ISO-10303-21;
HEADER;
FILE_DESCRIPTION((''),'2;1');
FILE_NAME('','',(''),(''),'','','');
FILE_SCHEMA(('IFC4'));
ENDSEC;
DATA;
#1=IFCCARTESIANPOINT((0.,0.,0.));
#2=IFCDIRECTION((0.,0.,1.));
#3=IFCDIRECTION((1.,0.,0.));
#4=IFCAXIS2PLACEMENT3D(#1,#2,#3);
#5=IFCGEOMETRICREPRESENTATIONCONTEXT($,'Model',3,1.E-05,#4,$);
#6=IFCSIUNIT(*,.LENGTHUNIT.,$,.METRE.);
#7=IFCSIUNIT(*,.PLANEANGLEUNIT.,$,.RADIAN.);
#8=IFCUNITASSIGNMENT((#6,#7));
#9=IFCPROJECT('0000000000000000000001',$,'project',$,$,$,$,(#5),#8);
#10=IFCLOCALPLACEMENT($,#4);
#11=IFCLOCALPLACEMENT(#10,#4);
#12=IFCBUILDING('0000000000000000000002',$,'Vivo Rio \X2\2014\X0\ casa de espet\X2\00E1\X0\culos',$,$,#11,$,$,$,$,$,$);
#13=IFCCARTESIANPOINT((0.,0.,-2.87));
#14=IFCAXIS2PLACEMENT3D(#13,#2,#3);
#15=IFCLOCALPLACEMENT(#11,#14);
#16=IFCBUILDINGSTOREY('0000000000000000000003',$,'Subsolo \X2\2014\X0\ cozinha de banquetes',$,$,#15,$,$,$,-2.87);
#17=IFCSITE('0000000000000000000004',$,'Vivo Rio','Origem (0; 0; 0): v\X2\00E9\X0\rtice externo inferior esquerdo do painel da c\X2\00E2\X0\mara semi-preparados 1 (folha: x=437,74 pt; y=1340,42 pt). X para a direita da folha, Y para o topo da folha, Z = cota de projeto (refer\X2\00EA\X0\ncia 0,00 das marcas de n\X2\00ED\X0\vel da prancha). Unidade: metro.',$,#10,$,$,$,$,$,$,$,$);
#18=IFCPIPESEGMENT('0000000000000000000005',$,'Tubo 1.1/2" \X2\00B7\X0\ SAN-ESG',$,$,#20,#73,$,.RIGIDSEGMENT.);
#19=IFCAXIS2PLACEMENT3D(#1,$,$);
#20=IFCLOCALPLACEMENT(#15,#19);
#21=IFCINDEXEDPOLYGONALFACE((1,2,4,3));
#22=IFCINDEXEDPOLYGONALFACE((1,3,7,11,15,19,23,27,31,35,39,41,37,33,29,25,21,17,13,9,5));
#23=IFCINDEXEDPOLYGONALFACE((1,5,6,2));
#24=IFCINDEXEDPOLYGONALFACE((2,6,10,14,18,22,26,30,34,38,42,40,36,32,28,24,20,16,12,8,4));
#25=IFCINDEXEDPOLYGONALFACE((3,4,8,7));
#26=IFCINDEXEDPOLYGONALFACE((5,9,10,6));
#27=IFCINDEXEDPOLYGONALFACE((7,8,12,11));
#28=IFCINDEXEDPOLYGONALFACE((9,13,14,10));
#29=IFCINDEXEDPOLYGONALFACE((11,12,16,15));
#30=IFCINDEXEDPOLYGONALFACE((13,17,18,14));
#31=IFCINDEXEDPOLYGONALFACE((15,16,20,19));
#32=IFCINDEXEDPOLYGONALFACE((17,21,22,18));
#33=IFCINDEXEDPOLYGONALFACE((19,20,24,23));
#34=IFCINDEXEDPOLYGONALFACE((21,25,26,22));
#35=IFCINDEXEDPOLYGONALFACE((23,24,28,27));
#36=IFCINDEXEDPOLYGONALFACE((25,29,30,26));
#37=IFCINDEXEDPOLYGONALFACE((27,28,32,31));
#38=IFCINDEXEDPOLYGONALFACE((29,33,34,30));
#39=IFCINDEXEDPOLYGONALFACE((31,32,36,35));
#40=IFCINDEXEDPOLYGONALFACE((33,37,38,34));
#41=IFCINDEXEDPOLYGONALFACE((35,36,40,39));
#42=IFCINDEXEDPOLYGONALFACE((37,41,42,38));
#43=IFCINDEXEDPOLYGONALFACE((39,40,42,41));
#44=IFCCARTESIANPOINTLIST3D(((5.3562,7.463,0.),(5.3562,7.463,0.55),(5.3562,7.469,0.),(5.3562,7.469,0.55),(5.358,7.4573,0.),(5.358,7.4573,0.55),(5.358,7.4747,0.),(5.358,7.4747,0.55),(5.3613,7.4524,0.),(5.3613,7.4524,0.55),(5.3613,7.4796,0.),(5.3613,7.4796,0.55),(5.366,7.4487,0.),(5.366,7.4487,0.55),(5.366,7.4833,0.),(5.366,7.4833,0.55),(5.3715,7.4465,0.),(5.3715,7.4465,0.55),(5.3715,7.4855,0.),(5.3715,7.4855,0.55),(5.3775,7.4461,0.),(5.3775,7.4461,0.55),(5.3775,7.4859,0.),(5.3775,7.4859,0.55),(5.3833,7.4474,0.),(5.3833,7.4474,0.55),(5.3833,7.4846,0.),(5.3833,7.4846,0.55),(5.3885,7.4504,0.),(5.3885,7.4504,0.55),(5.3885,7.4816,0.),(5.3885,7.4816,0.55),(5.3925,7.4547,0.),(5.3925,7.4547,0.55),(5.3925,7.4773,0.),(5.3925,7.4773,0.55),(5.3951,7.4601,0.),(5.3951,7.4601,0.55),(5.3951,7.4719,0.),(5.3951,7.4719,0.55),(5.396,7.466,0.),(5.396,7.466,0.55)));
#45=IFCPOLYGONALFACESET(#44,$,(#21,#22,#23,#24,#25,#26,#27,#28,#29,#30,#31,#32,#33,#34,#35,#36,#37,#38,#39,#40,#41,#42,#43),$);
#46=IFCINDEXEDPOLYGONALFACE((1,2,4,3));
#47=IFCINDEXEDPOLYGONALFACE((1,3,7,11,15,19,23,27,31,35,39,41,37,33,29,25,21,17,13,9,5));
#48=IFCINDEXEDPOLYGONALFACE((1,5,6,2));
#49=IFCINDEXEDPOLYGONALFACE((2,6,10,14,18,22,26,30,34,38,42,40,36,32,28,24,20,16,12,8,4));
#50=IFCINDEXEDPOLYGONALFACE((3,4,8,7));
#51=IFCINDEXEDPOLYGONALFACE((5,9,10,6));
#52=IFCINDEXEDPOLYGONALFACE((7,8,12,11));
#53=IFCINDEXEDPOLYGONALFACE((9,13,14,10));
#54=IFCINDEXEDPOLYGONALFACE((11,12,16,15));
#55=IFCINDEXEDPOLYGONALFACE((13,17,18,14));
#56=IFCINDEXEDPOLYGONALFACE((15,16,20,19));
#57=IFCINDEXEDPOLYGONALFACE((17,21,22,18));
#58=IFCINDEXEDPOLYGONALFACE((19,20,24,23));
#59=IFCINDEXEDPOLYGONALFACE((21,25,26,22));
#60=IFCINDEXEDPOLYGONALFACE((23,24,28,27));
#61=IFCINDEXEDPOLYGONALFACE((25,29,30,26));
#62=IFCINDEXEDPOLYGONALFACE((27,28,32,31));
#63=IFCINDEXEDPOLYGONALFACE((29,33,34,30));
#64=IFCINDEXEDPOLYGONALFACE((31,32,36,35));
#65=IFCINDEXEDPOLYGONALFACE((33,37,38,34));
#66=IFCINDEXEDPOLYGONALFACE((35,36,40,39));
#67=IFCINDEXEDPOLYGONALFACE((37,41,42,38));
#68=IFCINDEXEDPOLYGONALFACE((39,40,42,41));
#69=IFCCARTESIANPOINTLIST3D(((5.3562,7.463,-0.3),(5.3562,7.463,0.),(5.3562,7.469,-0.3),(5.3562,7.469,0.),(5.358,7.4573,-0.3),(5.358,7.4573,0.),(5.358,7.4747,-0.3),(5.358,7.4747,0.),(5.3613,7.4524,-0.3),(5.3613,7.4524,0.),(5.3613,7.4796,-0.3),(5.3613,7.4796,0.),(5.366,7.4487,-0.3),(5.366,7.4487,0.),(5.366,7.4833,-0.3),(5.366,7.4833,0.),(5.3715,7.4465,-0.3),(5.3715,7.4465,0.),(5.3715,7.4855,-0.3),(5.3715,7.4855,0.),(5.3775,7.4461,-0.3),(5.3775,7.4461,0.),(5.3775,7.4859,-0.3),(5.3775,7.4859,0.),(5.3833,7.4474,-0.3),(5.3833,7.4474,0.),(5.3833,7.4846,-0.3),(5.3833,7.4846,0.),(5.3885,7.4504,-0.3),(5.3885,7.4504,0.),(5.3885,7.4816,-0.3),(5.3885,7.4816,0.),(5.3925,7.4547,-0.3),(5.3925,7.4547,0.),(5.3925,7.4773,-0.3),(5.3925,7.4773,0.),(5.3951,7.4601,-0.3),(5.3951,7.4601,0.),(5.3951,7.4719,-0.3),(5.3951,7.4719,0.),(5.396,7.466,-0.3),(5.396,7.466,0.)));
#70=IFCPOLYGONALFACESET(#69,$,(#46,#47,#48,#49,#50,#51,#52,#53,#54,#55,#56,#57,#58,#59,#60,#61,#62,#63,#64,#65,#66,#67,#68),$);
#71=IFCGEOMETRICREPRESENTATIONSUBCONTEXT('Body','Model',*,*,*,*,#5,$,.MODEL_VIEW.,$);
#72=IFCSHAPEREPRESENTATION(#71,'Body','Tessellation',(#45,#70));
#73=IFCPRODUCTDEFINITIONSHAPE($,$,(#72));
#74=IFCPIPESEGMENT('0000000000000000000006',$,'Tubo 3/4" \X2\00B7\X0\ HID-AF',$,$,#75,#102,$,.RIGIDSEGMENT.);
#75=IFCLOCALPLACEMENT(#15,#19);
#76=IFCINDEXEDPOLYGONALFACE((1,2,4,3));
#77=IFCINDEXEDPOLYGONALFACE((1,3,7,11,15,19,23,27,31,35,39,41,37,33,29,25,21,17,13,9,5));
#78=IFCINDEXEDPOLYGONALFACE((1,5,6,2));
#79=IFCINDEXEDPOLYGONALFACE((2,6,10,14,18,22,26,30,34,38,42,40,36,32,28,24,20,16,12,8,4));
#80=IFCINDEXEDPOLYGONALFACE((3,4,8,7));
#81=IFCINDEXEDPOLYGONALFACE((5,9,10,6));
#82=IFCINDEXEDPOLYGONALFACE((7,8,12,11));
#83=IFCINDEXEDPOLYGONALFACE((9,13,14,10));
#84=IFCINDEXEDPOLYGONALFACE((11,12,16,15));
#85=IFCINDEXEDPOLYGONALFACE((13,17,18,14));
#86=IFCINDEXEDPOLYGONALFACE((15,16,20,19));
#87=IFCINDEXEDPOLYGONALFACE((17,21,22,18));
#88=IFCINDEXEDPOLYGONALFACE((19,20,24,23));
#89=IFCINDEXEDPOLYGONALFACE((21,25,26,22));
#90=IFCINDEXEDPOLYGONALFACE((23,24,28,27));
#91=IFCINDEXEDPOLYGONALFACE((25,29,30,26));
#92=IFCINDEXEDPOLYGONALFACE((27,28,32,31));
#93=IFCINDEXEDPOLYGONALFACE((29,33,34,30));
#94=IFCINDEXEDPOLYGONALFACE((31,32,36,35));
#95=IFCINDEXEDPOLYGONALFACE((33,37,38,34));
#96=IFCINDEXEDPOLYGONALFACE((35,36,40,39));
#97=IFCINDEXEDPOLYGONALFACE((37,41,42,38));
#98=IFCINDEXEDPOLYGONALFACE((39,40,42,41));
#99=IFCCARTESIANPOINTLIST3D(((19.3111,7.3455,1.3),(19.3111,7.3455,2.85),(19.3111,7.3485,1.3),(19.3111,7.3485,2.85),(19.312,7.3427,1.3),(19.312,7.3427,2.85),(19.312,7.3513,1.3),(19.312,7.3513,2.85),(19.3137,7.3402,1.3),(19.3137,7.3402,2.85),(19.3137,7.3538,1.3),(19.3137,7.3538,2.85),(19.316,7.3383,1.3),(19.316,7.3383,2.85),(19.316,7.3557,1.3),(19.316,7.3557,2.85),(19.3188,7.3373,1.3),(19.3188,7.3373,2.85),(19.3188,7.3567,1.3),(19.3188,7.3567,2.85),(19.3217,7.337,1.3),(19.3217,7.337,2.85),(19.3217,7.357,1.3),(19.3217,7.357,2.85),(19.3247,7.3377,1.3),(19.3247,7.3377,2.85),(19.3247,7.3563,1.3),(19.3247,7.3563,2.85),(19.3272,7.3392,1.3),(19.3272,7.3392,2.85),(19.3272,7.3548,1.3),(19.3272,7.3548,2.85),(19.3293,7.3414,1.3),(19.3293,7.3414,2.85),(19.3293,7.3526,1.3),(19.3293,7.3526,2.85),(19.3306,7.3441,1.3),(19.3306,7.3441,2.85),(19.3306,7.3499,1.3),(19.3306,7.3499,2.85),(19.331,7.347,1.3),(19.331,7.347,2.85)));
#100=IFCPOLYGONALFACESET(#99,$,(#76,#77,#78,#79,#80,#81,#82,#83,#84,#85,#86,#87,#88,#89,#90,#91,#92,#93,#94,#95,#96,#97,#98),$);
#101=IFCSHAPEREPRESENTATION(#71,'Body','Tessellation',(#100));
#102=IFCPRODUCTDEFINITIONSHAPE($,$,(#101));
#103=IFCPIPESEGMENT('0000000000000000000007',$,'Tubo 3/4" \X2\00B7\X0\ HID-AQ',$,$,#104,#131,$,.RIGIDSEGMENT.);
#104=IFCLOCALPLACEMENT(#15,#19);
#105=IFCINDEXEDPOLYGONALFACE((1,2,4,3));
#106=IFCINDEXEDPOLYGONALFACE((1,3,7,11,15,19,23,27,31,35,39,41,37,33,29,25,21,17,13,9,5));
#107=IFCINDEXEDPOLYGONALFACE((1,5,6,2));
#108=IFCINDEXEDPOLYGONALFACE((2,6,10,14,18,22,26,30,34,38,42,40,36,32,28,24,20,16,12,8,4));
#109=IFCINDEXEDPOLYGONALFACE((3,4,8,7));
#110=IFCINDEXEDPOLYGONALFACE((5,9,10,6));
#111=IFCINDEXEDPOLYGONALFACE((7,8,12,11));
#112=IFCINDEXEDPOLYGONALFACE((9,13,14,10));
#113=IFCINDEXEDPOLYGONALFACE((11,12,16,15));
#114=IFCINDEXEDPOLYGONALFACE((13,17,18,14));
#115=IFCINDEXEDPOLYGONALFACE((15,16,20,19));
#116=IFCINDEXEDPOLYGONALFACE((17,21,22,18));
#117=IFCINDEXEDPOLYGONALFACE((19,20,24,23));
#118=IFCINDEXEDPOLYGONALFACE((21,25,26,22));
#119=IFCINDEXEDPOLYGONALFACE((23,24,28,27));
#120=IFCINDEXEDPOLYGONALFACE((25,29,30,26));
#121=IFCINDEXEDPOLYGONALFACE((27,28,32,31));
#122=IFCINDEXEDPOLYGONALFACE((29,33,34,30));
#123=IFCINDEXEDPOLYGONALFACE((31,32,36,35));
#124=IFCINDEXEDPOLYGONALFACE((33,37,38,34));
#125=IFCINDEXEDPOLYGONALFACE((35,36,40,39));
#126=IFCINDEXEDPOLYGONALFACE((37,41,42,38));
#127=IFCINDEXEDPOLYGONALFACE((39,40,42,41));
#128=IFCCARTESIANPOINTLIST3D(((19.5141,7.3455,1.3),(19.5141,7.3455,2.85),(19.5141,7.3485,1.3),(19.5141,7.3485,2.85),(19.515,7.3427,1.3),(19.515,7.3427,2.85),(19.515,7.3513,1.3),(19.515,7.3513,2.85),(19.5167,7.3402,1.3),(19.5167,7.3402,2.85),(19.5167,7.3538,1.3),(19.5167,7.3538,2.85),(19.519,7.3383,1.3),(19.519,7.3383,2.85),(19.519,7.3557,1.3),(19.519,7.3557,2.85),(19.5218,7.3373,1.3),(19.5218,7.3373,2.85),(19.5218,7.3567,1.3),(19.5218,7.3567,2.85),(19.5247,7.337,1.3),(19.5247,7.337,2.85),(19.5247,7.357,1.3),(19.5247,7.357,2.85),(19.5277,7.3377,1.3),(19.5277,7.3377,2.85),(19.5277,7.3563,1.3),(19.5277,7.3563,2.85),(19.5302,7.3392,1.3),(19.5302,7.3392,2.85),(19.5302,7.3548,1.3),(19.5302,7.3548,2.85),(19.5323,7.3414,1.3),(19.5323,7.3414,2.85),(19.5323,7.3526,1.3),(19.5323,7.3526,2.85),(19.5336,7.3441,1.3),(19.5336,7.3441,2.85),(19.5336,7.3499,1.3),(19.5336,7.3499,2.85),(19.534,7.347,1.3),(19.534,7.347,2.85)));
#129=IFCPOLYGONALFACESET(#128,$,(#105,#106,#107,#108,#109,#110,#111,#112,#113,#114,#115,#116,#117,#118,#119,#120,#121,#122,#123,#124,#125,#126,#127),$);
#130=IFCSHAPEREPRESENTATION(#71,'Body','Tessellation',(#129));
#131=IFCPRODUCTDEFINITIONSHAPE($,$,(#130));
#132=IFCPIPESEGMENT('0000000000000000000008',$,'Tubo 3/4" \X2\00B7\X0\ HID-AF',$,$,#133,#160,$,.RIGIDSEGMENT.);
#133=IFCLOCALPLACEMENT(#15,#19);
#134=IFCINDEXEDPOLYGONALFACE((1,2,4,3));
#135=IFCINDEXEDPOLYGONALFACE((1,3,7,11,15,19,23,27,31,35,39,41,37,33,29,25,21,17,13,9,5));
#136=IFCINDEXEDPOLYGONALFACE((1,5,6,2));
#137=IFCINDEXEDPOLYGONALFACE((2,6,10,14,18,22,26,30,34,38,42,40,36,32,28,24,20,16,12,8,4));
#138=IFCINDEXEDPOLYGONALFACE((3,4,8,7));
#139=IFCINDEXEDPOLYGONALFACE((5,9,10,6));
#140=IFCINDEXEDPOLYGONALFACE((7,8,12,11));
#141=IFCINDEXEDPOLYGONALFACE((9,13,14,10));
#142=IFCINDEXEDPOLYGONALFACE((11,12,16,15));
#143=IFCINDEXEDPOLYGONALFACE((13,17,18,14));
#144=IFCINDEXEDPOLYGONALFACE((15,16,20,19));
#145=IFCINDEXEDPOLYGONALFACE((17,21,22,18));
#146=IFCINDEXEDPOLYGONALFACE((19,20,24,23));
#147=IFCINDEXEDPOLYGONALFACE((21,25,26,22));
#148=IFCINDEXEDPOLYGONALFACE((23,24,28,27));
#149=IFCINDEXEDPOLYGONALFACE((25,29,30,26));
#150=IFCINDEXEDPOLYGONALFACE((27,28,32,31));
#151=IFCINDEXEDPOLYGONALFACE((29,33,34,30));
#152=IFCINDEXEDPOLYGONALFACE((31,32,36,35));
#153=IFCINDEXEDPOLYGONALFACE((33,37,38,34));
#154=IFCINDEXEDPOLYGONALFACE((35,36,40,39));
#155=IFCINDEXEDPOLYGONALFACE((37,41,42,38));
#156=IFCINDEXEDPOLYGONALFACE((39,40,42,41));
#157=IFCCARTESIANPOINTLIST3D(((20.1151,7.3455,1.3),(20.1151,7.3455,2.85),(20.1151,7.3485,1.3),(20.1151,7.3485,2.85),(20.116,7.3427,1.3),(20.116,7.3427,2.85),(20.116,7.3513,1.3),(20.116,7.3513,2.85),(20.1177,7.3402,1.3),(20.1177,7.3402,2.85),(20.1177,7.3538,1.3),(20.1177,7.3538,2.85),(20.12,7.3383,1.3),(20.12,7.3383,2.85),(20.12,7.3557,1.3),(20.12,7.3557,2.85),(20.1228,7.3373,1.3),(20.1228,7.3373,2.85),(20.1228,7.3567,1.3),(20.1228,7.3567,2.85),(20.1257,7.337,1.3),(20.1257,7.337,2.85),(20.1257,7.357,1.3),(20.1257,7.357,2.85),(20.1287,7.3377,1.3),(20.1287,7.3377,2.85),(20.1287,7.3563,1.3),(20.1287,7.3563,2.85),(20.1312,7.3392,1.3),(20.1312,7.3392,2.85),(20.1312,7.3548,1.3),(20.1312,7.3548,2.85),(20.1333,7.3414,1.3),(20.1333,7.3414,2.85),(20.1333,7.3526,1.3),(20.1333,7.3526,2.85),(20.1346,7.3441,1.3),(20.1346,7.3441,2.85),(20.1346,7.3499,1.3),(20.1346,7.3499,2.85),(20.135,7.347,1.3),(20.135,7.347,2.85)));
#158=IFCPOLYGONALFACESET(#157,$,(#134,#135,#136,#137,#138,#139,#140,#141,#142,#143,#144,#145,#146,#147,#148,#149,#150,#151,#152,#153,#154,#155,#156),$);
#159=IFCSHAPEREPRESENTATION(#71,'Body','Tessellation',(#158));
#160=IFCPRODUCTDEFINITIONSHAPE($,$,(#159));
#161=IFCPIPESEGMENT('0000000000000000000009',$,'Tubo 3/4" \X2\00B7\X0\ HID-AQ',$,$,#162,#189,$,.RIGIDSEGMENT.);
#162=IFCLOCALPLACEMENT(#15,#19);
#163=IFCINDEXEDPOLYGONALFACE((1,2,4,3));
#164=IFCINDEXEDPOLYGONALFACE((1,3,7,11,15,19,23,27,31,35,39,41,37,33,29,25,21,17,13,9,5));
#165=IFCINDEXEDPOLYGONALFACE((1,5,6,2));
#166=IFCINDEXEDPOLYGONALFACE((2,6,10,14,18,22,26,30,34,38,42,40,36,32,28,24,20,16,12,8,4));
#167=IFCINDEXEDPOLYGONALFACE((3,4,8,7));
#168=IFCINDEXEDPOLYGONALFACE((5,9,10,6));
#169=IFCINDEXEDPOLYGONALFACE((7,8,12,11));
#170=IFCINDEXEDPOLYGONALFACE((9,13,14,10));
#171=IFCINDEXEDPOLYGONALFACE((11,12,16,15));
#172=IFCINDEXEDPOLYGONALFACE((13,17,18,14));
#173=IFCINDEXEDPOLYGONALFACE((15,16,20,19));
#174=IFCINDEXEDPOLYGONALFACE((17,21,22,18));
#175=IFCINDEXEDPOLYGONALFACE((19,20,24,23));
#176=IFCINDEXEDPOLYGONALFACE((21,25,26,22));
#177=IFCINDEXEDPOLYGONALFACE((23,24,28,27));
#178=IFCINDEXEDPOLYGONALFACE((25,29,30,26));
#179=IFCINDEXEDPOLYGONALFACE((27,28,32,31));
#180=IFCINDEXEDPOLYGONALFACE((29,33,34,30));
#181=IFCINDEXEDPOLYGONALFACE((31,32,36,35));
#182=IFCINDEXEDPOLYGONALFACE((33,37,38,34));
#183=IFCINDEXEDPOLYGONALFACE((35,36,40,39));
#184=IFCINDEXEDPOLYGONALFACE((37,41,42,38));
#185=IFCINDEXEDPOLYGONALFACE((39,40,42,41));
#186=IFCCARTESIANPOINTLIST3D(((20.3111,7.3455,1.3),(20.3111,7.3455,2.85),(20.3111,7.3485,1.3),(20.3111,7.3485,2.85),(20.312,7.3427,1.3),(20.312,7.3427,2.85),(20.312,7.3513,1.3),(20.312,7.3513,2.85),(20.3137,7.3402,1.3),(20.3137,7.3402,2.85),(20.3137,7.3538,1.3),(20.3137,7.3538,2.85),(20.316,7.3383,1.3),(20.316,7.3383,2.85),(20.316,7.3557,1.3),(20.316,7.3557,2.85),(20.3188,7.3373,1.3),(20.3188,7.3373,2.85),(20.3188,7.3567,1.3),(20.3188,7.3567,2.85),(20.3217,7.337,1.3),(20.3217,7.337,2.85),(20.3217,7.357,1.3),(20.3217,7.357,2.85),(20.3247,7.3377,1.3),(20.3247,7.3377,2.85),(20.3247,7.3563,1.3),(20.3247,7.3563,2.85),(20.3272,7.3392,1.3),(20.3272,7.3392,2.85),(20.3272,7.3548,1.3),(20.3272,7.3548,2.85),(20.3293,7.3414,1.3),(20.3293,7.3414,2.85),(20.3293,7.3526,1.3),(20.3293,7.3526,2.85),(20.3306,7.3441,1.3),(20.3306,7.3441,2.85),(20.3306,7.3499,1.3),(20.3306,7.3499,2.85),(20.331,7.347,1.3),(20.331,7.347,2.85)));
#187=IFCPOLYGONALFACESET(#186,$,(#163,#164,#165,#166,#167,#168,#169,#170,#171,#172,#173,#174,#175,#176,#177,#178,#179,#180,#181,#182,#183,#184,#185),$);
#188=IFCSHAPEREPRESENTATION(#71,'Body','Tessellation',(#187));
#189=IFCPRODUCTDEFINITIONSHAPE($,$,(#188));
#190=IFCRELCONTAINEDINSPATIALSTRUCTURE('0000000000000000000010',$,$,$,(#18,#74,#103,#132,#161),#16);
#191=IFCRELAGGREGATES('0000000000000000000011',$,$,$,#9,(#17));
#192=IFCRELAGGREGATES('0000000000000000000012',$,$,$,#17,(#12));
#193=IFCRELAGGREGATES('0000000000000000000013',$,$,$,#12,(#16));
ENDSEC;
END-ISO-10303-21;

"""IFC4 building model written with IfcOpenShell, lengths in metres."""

from ifc_helpers import new_model, si_unit, frame, origin_with_axes, origin_2d, place, context, subcontext, project, spatial, circle, extrude, element, save


model = new_model("IFC4")

# Units and contexts
model_context = context("Model", 3, precision=1e-05, world=origin_with_axes())
body_context = subcontext(model_context, "Body", "Model", "MODEL_VIEW")
ifc_project = project(units=[si_unit("LENGTHUNIT", "METRE"), si_unit("PLANEANGLEUNIT", "RADIAN")], contexts=[model_context])

# Site, building, storey
site_placement = place(None, origin_with_axes())
site = spatial("IfcSite", under=ifc_project, at=site_placement, Name="Vivo Rio", Description="Origem (0; 0; 0): vértice externo inferior esquerdo do painel da câmara semi-preparados 1 (folha: x=437,74 pt; y=1340,42 pt). X para a direita da folha, Y para o topo da folha, Z = cota de projeto (referência 0,00 das marcas de nível da prancha). Unidade: metro.")
building_placement = place(site_placement, origin_with_axes())
building = spatial("IfcBuilding", under=site, at=building_placement, Name="Vivo Rio — casa de espetáculos")
storey_placement = place(building_placement, frame((0.0, 0.0, -2.87), z_axis=(0.0, 0.0, 1.0), x_axis=(1.0, 0.0, 0.0)))
storey = spatial("IfcBuildingStorey", under=building, at=storey_placement, Name="Subsolo — cozinha de banquetes", Elevation=-2.87)

# Pipe segments
pipe_segment_1_placement = place(storey_placement, origin_with_axes())
element("IfcPipeSegment", 1, at=pipe_segment_1_placement, inside=storey, Name="Tubo 1.1/2\" · SAN-ESG", PredefinedType="RIGIDSEGMENT", context=body_context, shape_type="SweptSolid", body=[
    extrude(circle(Radius=0.02, at=origin_2d()), frame((5.376, 7.466, 0.55), z_axis=(0.0, 0.0, -1.0), x_axis=(1.0, 0.0, 0.0)), (0.0, 0.0, 1.0), 0.55),
    extrude(circle(Radius=0.02, at=origin_2d()), frame((5.376, 7.466, 0.0), z_axis=(0.0, 0.0, -1.0), x_axis=(1.0, 0.0, 0.0)), (0.0, 0.0, 1.0), 0.3),
])
pipe_segment_2_placement = place(storey_placement, origin_with_axes())
element("IfcPipeSegment", 2, at=pipe_segment_2_placement, inside=storey, Name="Tubo 3/4\" · HID-AF", PredefinedType="RIGIDSEGMENT", context=body_context, shape_type="SweptSolid", body=[
    extrude(circle(Radius=0.01, at=origin_2d()), frame((19.321, 7.347, 2.85), z_axis=(0.0, 0.0, -1.0), x_axis=(1.0, 0.0, 0.0)), (0.0, 0.0, 1.0), 1.55),
])
pipe_segment_3_placement = place(storey_placement, origin_with_axes())
element("IfcPipeSegment", 3, at=pipe_segment_3_placement, inside=storey, Name="Tubo 3/4\" · HID-AQ", PredefinedType="RIGIDSEGMENT", context=body_context, shape_type="SweptSolid", body=[
    extrude(circle(Radius=0.01, at=origin_2d()), frame((19.524, 7.347, 2.85), z_axis=(0.0, 0.0, -1.0), x_axis=(1.0, 0.0, 0.0)), (0.0, 0.0, 1.0), 1.55),
])
pipe_segment_4_placement = place(storey_placement, origin_with_axes())
element("IfcPipeSegment", 4, at=pipe_segment_4_placement, inside=storey, Name="Tubo 3/4\" · HID-AF", PredefinedType="RIGIDSEGMENT", context=body_context, shape_type="SweptSolid", body=[
    extrude(circle(Radius=0.01, at=origin_2d()), frame((20.125, 7.347, 2.85), z_axis=(0.0, 0.0, -1.0), x_axis=(1.0, 0.0, 0.0)), (0.0, 0.0, 1.0), 1.55),
])
pipe_segment_5_placement = place(storey_placement, origin_with_axes())
element("IfcPipeSegment", 5, at=pipe_segment_5_placement, inside=storey, Name="Tubo 3/4\" · HID-AQ", PredefinedType="RIGIDSEGMENT", context=body_context, shape_type="SweptSolid", body=[
    extrude(circle(Radius=0.01, at=origin_2d()), frame((20.321, 7.347, 2.85), z_axis=(0.0, 0.0, -1.0), x_axis=(1.0, 0.0, 0.0)), (0.0, 0.0, 1.0), 1.55),
])

save(model, "model.ifc")
